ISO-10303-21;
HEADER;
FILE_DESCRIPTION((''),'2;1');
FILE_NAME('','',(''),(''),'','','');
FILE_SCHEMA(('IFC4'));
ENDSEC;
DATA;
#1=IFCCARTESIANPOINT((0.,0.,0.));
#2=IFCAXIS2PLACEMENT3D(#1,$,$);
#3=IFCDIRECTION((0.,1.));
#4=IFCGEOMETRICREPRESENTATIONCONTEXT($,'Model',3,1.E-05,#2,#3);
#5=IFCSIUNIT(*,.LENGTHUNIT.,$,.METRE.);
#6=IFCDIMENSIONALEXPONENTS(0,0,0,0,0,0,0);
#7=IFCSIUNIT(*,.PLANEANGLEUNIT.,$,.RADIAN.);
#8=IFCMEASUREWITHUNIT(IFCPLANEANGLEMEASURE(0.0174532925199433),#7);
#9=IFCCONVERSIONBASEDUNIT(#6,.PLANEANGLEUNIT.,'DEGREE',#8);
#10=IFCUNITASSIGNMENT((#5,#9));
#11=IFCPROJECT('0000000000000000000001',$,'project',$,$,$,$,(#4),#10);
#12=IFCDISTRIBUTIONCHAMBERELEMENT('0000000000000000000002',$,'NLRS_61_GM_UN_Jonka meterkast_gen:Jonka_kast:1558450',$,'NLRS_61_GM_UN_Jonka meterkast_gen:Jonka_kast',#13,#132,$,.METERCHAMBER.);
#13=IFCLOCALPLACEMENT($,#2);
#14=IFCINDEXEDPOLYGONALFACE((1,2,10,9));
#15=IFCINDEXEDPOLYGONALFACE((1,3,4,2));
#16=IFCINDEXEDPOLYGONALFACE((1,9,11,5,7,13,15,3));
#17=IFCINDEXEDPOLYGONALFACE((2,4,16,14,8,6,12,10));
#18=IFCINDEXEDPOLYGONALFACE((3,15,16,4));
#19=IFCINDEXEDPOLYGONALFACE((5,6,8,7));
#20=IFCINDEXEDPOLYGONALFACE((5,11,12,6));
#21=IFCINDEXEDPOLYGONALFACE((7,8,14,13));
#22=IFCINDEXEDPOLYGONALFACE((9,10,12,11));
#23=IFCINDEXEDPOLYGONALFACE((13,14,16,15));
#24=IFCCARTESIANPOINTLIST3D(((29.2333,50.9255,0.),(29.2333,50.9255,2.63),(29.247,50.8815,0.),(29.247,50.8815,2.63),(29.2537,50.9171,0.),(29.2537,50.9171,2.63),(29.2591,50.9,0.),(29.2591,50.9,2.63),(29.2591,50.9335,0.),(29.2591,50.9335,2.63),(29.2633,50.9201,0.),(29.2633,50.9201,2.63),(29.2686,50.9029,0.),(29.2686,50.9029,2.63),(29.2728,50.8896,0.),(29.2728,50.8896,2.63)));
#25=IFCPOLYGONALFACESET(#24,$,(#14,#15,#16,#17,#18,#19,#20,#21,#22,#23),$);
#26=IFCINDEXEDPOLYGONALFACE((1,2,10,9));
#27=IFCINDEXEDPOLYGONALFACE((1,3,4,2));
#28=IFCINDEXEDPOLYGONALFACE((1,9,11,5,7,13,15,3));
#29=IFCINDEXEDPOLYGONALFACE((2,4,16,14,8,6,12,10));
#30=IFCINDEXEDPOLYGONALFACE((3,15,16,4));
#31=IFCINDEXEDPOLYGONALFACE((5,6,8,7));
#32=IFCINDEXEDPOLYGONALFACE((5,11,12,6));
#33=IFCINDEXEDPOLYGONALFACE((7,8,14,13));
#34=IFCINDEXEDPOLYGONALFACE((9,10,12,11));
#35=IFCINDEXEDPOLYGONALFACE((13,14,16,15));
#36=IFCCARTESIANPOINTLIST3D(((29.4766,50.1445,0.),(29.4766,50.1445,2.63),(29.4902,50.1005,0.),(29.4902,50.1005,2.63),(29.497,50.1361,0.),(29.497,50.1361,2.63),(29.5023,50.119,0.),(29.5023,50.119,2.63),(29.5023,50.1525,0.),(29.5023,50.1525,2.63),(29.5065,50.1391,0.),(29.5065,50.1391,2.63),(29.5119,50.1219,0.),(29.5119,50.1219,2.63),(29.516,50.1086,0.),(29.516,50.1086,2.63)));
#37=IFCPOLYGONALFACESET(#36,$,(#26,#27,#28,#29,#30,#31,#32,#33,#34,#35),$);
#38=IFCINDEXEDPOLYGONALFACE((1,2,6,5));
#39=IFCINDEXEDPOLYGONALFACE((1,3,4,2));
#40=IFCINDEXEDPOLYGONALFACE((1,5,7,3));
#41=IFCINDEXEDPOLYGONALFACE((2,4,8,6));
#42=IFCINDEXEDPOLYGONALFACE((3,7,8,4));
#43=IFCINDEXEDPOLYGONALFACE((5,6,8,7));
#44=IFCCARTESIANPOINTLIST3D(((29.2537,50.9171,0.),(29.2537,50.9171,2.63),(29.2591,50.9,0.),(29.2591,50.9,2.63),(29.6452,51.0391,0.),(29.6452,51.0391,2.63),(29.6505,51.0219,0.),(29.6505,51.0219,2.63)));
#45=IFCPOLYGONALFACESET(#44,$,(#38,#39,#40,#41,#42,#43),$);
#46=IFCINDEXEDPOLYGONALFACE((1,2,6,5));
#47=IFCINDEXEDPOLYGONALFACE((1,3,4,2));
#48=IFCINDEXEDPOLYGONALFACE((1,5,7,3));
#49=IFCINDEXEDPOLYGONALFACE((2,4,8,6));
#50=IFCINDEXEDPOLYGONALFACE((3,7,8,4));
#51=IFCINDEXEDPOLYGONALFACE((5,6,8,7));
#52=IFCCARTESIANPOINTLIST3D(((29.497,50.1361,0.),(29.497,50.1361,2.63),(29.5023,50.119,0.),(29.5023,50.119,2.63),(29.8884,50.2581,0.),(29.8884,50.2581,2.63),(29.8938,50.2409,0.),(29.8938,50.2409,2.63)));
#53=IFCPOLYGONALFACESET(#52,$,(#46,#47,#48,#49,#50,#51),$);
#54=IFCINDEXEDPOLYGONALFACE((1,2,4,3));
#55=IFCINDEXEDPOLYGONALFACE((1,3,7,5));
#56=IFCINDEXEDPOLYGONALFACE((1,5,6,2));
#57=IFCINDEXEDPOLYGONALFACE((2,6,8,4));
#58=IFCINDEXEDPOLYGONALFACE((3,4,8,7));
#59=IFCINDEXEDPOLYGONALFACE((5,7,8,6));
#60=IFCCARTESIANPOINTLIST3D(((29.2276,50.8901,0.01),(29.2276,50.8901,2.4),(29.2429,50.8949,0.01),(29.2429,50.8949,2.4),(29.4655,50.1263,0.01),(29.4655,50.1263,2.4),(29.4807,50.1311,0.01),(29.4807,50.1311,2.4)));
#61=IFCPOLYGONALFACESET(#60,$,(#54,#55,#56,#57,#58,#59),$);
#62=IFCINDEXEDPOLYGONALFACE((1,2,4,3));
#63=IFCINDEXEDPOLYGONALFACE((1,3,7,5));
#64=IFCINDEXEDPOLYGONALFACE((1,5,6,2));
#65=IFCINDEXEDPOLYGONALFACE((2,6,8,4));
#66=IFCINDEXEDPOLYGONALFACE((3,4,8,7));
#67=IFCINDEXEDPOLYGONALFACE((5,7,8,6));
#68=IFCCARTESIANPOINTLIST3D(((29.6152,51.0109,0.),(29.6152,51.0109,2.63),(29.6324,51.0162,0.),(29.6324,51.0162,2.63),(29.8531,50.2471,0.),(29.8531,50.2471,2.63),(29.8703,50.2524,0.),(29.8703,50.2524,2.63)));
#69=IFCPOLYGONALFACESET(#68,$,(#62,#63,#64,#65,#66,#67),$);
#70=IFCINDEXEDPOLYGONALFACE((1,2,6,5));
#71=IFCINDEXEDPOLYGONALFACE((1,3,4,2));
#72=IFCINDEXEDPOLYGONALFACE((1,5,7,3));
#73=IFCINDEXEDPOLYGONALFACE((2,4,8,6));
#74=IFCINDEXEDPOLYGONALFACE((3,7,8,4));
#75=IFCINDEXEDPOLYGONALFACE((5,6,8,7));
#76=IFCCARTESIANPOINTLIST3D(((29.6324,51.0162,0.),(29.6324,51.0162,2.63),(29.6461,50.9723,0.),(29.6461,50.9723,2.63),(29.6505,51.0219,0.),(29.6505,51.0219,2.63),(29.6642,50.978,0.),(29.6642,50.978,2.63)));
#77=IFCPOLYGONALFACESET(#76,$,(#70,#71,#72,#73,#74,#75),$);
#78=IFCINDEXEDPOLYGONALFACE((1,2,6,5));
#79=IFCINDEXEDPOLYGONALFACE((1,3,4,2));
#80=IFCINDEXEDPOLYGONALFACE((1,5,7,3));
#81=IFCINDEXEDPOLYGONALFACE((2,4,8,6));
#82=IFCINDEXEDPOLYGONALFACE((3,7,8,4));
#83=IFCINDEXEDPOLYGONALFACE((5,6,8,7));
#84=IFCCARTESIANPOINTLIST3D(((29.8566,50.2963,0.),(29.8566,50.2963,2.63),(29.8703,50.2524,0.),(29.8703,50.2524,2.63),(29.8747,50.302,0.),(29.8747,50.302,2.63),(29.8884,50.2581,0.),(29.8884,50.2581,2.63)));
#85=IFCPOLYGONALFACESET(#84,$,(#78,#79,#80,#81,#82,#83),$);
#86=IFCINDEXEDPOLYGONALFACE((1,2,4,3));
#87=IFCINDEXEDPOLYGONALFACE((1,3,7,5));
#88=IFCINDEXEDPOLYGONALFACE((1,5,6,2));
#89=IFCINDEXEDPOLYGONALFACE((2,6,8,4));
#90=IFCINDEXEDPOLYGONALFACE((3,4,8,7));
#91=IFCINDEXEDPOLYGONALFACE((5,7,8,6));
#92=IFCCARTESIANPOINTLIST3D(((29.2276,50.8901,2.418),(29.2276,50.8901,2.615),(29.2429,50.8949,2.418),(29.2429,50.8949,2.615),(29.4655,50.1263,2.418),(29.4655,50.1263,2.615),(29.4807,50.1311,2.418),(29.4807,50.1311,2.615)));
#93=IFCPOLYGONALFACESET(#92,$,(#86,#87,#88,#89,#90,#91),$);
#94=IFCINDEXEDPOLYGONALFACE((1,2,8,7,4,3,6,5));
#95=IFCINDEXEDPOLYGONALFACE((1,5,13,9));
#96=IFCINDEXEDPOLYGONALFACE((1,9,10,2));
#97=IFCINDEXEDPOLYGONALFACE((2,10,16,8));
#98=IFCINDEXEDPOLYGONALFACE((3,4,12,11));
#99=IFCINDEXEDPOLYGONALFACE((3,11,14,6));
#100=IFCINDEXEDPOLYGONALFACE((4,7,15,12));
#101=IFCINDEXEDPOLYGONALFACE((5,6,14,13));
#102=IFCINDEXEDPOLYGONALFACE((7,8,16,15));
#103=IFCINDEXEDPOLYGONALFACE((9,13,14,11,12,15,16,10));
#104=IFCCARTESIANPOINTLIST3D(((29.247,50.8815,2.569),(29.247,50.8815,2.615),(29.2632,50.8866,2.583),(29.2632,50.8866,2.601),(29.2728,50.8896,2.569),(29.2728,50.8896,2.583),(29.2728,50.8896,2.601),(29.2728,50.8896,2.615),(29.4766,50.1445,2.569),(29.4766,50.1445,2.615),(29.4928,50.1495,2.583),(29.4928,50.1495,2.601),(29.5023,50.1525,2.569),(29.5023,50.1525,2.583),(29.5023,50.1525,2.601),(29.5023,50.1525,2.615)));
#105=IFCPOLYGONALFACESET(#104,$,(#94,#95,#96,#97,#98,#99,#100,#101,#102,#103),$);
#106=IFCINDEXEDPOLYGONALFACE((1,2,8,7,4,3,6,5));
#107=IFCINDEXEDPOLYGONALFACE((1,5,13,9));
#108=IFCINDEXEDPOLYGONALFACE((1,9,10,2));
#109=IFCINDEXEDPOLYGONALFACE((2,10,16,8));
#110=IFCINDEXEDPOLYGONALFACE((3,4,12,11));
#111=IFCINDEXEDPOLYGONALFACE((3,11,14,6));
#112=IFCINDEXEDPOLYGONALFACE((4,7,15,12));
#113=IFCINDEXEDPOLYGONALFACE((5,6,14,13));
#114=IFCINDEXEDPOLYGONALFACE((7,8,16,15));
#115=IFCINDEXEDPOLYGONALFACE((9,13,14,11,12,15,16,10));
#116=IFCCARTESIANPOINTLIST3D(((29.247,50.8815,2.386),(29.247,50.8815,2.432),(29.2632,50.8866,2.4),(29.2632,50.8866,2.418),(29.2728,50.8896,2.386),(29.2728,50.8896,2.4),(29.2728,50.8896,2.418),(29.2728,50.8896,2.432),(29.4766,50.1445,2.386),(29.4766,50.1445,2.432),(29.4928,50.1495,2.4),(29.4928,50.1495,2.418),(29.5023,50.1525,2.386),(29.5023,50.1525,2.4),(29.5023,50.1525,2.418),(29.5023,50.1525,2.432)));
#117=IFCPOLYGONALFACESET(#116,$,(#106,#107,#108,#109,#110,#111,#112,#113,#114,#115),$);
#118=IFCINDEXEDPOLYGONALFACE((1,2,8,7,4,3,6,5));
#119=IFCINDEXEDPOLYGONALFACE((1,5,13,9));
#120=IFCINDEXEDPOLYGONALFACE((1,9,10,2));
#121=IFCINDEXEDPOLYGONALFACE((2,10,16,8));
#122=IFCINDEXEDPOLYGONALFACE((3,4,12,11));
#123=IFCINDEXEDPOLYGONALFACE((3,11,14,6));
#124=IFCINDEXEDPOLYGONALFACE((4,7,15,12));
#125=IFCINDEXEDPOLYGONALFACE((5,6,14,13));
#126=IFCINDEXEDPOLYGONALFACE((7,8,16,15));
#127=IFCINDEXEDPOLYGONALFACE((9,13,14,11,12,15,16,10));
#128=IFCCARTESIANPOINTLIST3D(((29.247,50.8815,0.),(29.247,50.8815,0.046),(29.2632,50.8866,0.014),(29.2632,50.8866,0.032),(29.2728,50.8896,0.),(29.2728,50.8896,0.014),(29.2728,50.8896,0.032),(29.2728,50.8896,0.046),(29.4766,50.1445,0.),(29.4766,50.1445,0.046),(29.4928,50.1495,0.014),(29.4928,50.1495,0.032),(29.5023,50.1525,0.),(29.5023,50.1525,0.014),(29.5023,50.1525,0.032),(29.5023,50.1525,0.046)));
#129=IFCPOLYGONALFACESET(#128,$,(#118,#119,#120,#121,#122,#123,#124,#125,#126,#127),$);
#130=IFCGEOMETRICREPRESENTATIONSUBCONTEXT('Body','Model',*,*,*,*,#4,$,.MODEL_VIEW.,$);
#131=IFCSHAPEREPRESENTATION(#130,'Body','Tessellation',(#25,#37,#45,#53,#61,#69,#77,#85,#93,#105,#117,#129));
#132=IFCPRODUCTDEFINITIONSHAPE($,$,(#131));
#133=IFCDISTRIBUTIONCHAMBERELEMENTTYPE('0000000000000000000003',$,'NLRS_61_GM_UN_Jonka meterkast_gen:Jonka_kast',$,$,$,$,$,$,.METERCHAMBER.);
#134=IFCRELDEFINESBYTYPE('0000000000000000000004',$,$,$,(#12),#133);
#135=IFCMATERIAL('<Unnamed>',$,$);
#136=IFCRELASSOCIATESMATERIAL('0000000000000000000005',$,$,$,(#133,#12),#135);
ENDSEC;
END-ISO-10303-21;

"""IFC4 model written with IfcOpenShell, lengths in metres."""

from ifc_helpers import new_model, entity, si_unit, converted_unit, direction, frame, origin, place, context, subcontext, project, indexed_curve, outline, extrude, source, transform, mapped, material, type_object, type_shapes, element, save


model = new_model("IFC4")

# Units and contexts
model_context = context("Model", 3, precision=1e-05, world=origin(), true_north=direction((0.0, 1.0)))
body_context = subcontext(model_context, "Body", "Model", "MODEL_VIEW")
ifc_project = project(units=[si_unit("LENGTHUNIT", "METRE"), converted_unit("PLANEANGLEUNIT", "DEGREE", entity("IfcPlaneAngleMeasure", 0.0174532925199433), si_unit("PLANEANGLEUNIT", "RADIAN"), dimensions=[0, 0, 0, 0, 0, 0, 0])], contexts=[model_context])

# Distribution chamber element
ifc_material = material(Name="<Unnamed>")
distribution_chamber_element_type = type_object("IfcDistributionChamberElementType", Name="NLRS_61_GM_UN_Jonka meterkast_gen:Jonka_kast", PredefinedType="METERCHAMBER", material=ifc_material)
shared_shape_1 = source(origin(), body_context, "Body", "SweptSolid", [
    extrude(outline(indexed_curve([(-0.0093, -0.023), (0.0178, -0.023), (0.0178, 0.023), (-0.0093, 0.023), (-0.0093, 0.009), (0.0007, 0.009), (0.0007, -0.009), (-0.0093, -0.009), (-0.0093, -0.023)], self_intersect=False)), frame((-0.409, -0.4092, 0.0), z_axis=(0.0, 0.0, 1.0), x_axis=(0.0, -1.0, 0.0)), (0.0, 0.0, 1.0), 2.63),
    extrude(outline(indexed_curve([(-0.0093, -0.023), (0.0178, -0.023), (0.0178, 0.023), (-0.0093, 0.023), (-0.0093, 0.009), (0.0007, 0.009), (0.0007, -0.009), (-0.0093, -0.009), (-0.0093, -0.023)], self_intersect=False)), frame((0.409, -0.4092, 0.0), z_axis=(0.0, 0.0, 1.0), x_axis=(0.0, -1.0, 0.0)), (0.0, 0.0, 1.0), 2.63),
    extrude(outline(indexed_curve([(-0.205, -0.009), (0.205, -0.009), (0.205, 0.009), (-0.205, 0.009), (-0.205, -0.009)], self_intersect=False)), frame((-0.409, -0.205, 0.0), z_axis=(0.0, 0.0, 1.0), x_axis=(0.0, -1.0, 0.0)), (0.0, 0.0, 1.0), 2.63),
    extrude(outline(indexed_curve([(-0.205, -0.009), (0.205, -0.009), (0.205, 0.009), (-0.205, 0.009), (-0.205, -0.009)], self_intersect=False)), frame((0.409, -0.205, 0.0), z_axis=(0.0, 0.0, 1.0), x_axis=(0.0, -1.0, 0.0)), (0.0, 0.0, 1.0), 2.63),
    extrude(outline(indexed_curve([(-0.4, -0.008), (0.4, -0.008), (0.4, 0.008), (-0.4, 0.008), (-0.4, -0.008)], self_intersect=False)), frame((0.0, -0.435, 0.01), z_axis=(0.0, 0.0, 1.0), x_axis=(-1.0, 0.0, 0.0)), (0.0, 0.0, 1.0), 2.39),
    extrude(outline(indexed_curve([(-0.4, -0.009), (0.4, -0.009), (0.4, 0.009), (-0.4, 0.009), (-0.4, -0.009)], self_intersect=False)), frame((0.0, -0.028, 0.0), z_axis=(0.0, 0.0, 1.0), x_axis=(-1.0, 0.0, 0.0)), (0.0, 0.0, 1.0), 2.63),
    extrude(outline(indexed_curve([(-0.023, -0.0095), (0.023, -0.0095), (0.023, 0.0095), (-0.023, 0.0095), (-0.023, -0.0095)], self_intersect=False)), frame((-0.377, -0.0095, 0.0), z_axis=(0.0, 0.0, 1.0), x_axis=(-1.0, 0.0, 0.0)), (0.0, 0.0, 1.0), 2.63),
    extrude(outline(indexed_curve([(-0.023, -0.0095), (0.023, -0.0095), (0.023, 0.0095), (-0.023, 0.0095), (-0.023, -0.0095)], self_intersect=False)), frame((0.377, -0.0095, 0.0), z_axis=(0.0, 0.0, 1.0), x_axis=(-1.0, 0.0, 0.0)), (0.0, 0.0, 1.0), 2.63),
    extrude(outline(indexed_curve([(-0.4, -0.008), (0.4, -0.008), (0.4, 0.008), (-0.4, 0.008), (-0.4, -0.008)], self_intersect=False)), frame((0.0, -0.435, 2.418), z_axis=(0.0, 0.0, 1.0), x_axis=(-1.0, 0.0, 0.0)), (0.0, 0.0, 1.0), 0.197),
    extrude(outline(indexed_curve([(-0.023, -0.0178), (0.023, -0.0178), (0.023, 0.0093), (0.009, 0.0093), (0.009, -0.0007), (-0.009, -0.0007), (-0.009, 0.0093), (-0.023, 0.0093), (-0.023, -0.0178)], self_intersect=False)), frame((-0.386, -0.4092, 2.592), z_axis=(1.0, 0.0, 0.0), x_axis=(0.0, 0.0, -1.0)), (0.0, 0.0, 1.0), 0.772),
    extrude(outline(indexed_curve([(-0.023, -0.0178), (0.023, -0.0178), (0.023, 0.0093), (0.009, 0.0093), (0.009, -0.0007), (-0.009, -0.0007), (-0.009, 0.0093), (-0.023, 0.0093), (-0.023, -0.0178)], self_intersect=False)), frame((-0.386, -0.4092, 2.409), z_axis=(1.0, 0.0, 0.0), x_axis=(0.0, 0.0, -1.0)), (0.0, 0.0, 1.0), 0.772),
    extrude(outline(indexed_curve([(-0.023, -0.0178), (0.023, -0.0178), (0.023, 0.0093), (0.009, 0.0093), (0.009, -0.0007), (-0.009, -0.0007), (-0.009, 0.0093), (-0.023, 0.0093), (-0.023, -0.0178)], self_intersect=False)), frame((-0.386, -0.4092, 0.023), z_axis=(1.0, 0.0, 0.0), x_axis=(0.0, 0.0, -1.0)), (0.0, 0.0, 1.0), 0.772),
])
type_shapes(distribution_chamber_element_type, [shared_shape_1])
placement_1 = place(None, frame((13.1348, 11.9886, 0.0), z_axis=(0.0, 0.0, 1.0), x_axis=(0.954771, 0.297342, 0.0)))
placement_2 = place(placement_1, origin())
placement_3 = place(placement_2, origin())
placement_4 = place(placement_3, origin())
distribution_chamber_element_1_placement = place(placement_4, frame((27.375, 31.957, 0.0), z_axis=(0.0, 0.0, 1.0), x_axis=(0.0, -1.0, 0.0)))
element("IfcDistributionChamberElement", 1, at=distribution_chamber_element_1_placement, type_object=distribution_chamber_element_type, material=ifc_material, Name="NLRS_61_GM_UN_Jonka meterkast_gen:Jonka_kast:1558450", ObjectType="NLRS_61_GM_UN_Jonka meterkast_gen:Jonka_kast", PredefinedType="METERCHAMBER", context=body_context, shape_type="MappedRepresentation", body=[
    mapped(shared_shape_1, transform((0.0, 0.0, 0.0), scale=1.0)),
])

save(model, "model.ifc")
